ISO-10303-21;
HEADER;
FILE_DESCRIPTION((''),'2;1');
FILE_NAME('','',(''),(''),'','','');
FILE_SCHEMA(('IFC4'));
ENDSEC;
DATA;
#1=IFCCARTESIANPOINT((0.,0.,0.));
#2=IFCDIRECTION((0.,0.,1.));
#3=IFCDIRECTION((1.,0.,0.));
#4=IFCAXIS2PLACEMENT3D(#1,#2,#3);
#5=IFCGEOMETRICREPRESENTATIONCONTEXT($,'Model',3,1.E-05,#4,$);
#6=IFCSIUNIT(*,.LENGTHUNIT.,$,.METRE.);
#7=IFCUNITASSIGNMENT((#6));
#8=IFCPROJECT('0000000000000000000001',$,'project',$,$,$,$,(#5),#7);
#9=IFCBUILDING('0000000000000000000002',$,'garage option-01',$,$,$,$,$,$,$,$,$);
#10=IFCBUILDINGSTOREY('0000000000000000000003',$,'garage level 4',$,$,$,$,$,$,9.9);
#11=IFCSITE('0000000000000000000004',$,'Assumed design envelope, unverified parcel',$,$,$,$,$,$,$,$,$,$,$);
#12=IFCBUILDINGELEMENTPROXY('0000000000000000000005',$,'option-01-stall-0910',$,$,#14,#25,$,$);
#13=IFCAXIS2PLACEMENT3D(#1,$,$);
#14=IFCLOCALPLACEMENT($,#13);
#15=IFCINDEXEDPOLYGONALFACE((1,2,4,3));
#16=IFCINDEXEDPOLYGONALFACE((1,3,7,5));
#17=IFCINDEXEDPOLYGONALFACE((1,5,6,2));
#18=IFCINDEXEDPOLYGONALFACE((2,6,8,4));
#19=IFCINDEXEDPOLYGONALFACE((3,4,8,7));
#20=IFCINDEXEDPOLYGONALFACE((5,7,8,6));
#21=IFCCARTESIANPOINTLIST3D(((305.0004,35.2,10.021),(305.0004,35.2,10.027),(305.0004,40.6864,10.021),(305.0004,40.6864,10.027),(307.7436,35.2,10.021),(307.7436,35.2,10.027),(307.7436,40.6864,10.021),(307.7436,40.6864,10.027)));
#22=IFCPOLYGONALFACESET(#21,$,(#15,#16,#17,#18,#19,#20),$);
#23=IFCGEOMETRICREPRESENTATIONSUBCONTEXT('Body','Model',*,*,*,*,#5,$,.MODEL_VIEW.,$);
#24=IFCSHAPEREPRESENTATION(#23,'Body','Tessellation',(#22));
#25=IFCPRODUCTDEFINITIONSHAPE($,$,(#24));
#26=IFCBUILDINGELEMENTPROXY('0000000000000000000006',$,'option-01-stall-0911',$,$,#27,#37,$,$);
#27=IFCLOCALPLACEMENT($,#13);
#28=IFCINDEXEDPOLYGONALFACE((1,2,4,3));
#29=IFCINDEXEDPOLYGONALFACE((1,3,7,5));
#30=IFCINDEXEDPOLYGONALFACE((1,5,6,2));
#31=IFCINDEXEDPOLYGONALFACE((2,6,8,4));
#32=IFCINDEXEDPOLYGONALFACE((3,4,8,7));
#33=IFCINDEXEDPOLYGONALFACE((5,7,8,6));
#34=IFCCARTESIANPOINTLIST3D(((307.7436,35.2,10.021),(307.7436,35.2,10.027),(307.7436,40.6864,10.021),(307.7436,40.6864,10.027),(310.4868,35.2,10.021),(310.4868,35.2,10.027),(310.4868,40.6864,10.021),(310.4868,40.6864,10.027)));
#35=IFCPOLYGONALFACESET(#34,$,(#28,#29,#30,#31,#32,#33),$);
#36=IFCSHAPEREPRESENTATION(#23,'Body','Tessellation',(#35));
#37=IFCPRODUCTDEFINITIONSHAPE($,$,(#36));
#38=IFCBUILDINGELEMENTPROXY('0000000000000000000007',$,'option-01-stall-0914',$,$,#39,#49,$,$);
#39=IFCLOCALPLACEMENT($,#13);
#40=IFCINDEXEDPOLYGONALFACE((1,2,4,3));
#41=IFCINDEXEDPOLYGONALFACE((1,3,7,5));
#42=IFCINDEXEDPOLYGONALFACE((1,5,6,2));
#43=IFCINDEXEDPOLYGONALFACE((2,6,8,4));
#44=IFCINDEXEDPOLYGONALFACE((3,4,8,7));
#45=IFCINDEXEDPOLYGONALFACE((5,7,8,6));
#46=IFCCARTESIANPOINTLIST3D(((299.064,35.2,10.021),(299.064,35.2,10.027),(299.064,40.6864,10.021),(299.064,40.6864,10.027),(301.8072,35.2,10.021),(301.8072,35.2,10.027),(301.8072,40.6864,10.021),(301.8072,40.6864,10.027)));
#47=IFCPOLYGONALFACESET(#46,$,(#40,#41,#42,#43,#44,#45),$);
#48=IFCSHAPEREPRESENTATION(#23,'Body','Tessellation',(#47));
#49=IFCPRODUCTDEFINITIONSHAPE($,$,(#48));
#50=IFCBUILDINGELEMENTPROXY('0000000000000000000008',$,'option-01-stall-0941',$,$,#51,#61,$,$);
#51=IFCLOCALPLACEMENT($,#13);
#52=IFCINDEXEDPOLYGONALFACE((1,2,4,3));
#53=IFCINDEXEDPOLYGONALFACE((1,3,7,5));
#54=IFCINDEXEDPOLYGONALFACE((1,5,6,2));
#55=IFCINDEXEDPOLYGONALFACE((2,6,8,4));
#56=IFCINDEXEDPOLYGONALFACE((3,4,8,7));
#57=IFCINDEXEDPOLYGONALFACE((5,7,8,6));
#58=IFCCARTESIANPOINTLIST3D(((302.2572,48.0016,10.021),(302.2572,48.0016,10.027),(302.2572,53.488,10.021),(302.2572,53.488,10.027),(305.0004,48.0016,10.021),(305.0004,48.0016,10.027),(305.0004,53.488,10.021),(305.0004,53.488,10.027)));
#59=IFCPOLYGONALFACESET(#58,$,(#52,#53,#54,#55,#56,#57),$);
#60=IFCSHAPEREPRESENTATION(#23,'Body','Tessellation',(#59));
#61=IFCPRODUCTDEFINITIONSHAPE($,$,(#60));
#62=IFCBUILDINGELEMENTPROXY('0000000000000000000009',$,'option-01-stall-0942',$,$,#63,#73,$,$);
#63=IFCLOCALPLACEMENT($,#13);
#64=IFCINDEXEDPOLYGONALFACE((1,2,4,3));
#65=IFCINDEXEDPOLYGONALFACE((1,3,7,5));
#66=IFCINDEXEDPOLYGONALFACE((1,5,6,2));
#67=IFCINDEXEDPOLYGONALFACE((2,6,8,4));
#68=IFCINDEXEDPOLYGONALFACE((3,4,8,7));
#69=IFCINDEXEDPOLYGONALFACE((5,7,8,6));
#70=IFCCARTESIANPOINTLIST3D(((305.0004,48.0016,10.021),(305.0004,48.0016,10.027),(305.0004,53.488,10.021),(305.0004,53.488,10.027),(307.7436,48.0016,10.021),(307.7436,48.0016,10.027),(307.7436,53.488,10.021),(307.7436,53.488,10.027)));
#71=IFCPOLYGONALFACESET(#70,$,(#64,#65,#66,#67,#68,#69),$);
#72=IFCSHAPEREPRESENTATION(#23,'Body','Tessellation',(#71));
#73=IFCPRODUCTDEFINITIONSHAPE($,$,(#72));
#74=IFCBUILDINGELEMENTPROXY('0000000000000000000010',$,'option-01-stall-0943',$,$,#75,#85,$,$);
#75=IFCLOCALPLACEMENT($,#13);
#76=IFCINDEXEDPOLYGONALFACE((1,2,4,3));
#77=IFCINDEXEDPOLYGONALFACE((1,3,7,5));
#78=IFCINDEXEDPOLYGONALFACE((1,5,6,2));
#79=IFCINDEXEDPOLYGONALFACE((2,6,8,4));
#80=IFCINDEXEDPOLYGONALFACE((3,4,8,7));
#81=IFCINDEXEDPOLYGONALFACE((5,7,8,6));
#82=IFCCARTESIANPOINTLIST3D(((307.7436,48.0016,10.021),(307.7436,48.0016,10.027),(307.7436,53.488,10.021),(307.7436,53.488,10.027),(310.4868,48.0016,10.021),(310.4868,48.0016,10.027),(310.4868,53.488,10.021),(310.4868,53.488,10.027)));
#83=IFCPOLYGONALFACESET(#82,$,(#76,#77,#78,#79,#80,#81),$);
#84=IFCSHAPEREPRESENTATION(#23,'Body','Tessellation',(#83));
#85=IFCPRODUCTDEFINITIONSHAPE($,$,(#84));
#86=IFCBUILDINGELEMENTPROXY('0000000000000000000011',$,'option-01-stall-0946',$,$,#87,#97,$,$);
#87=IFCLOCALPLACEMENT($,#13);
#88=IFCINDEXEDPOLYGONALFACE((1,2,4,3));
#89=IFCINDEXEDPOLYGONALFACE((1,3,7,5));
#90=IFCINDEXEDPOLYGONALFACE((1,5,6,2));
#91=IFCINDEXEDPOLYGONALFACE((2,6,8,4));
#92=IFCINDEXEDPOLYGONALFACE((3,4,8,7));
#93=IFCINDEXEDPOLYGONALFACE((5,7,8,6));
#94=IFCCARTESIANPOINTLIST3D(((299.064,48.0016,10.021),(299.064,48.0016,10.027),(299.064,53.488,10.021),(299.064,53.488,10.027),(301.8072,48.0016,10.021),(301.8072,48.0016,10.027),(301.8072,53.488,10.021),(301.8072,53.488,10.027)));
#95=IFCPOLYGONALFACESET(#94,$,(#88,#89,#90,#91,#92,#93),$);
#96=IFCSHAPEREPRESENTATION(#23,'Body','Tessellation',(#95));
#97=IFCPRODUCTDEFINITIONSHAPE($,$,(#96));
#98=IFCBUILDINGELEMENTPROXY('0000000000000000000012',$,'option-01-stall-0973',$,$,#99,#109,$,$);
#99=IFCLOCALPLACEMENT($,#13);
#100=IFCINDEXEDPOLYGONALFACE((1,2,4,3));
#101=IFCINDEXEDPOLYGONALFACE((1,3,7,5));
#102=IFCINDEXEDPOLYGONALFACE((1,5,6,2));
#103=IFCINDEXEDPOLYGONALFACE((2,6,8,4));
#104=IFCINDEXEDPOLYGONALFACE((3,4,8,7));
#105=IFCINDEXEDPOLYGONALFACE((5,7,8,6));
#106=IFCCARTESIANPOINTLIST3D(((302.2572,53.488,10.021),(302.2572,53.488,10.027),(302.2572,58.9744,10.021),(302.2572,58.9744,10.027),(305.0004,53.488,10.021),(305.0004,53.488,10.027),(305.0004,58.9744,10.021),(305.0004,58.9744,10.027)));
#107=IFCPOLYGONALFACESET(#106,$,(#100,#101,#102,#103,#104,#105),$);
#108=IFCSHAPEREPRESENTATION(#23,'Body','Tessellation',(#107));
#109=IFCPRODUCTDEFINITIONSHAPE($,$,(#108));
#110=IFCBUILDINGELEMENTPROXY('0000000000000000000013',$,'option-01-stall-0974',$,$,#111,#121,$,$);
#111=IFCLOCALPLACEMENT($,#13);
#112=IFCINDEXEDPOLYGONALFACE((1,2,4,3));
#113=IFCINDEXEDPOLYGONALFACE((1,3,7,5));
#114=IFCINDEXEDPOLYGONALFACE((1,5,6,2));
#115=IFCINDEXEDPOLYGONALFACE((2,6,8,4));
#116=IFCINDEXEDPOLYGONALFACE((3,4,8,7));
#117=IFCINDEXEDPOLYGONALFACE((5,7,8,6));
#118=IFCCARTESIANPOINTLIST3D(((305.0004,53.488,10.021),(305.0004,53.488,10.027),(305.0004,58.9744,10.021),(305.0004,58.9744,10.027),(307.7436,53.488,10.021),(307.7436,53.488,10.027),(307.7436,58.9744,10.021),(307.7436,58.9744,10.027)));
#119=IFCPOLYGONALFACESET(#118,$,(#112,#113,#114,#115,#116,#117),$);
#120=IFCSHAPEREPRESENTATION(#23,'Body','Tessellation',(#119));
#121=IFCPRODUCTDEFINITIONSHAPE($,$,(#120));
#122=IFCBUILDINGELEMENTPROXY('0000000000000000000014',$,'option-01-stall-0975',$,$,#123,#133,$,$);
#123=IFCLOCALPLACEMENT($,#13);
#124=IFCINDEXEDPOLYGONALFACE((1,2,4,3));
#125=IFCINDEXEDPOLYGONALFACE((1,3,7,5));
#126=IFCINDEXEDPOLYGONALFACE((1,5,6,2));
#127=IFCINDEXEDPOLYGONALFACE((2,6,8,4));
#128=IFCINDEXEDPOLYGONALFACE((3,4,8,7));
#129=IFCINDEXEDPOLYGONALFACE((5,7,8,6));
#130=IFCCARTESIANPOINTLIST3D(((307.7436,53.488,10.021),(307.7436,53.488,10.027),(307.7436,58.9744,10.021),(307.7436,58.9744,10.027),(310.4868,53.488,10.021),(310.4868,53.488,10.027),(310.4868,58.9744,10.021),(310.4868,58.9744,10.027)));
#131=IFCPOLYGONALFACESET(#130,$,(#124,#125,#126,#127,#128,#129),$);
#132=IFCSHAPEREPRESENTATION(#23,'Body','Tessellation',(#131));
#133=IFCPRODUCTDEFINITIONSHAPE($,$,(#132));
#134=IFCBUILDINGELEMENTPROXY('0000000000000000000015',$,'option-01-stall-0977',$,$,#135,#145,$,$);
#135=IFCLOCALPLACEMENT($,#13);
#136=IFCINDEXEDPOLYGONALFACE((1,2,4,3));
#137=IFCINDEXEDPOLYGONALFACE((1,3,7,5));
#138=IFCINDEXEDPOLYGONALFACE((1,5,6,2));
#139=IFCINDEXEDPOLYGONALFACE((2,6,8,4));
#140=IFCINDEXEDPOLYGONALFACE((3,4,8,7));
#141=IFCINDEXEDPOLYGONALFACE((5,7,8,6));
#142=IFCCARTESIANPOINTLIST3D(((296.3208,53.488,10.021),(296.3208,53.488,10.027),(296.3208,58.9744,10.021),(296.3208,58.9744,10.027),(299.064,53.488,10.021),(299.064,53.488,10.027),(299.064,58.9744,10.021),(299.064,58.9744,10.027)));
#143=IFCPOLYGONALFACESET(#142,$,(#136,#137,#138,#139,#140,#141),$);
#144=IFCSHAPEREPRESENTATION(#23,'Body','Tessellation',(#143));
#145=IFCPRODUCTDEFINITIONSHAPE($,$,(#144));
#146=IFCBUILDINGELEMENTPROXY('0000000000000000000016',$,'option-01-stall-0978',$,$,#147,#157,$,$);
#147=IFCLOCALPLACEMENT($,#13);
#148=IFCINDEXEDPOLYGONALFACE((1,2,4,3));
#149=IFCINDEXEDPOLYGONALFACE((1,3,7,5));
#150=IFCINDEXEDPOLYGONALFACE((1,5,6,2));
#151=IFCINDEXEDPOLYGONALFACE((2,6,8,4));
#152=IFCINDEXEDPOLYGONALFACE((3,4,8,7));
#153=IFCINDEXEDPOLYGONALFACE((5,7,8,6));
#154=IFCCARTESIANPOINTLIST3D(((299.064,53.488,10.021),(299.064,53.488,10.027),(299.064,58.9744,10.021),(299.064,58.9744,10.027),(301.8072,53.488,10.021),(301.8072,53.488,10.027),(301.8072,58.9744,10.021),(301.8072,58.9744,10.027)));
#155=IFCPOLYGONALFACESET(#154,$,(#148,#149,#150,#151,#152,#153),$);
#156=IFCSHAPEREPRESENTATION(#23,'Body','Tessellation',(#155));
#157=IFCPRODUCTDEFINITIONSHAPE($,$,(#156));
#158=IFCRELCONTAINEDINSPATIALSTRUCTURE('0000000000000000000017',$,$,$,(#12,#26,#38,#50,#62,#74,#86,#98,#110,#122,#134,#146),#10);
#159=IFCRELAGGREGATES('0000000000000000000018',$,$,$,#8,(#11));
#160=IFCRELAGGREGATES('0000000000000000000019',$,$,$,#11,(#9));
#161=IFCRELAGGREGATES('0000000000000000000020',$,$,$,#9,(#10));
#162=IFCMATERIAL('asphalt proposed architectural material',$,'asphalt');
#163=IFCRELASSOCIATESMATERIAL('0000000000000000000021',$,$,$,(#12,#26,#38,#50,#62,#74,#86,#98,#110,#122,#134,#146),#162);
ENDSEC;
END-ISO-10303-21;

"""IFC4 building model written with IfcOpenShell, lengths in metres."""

from ifc_helpers import new_model, si_unit, frame, origin_with_axes, place, context, subcontext, project, spatial, rectangle, extrude, material, element, save


model = new_model("IFC4")

# Units and contexts
model_context = context("Model", 3, precision=1e-05, world=origin_with_axes())
body_context = subcontext(model_context, "Body", "Model", "MODEL_VIEW")
ifc_project = project(units=[si_unit("LENGTHUNIT", "METRE")], contexts=[model_context])

# Site, building, storey
site = spatial("IfcSite", under=ifc_project, Name="Assumed design envelope, unverified parcel")
building = spatial("IfcBuilding", under=site, Name="garage option-01")
storey = spatial("IfcBuildingStorey", under=building, Name="garage level 4", Elevation=9.9)

# Building element proxies
ifc_material_1 = material(Name="asphalt proposed architectural material", Category="asphalt")
for number, where, z_axis, x_axis, name in (
    (1, (306.372, 37.9432, 10.021), (0.0, 0.0, 1.0), (1.0, 0.0, 0.0), "option-01-stall-0910"),
    (2, (309.1152, 37.9432, 10.021), (0.0, 0.0, 1.0), (1.0, 0.0, 0.0), "option-01-stall-0911"),
    (3, (300.4356, 37.9432, 10.021), (0.0, 0.0, 1.0), (1.0, 0.0, 0.0), "option-01-stall-0914"),
    (4, (303.6288, 50.7448, 10.021), (0.0, 0.0, 1.0), (1.0, 0.0, 0.0), "option-01-stall-0941"),
    (5, (306.372, 50.7448, 10.021), (0.0, 0.0, 1.0), (1.0, 0.0, 0.0), "option-01-stall-0942"),
    (6, (309.1152, 50.7448, 10.021), (0.0, 0.0, 1.0), (1.0, 0.0, 0.0), "option-01-stall-0943"),
    (7, (300.4356, 50.7448, 10.021), (0.0, 0.0, 1.0), (1.0, 0.0, 0.0), "option-01-stall-0946"),
):
    element("IfcBuildingElementProxy", number, at=place(None, frame(where, z_axis=z_axis, x_axis=x_axis)), inside=storey, material=ifc_material_1, Name=name, context=body_context, shape_type="SweptSolid", body=[
        extrude(rectangle(XDim=2.7432, YDim=5.4864), origin_with_axes(), (0.0, 0.0, 1.0), 0.006),
    ])
for number, where, z_axis, x_axis, name in (
    (8, (303.6288, 56.2312, 10.021), (0.0, 0.0, 1.0), (1.0, 0.0, 0.0), "option-01-stall-0973"),
    (9, (306.372, 56.2312, 10.021), (0.0, 0.0, 1.0), (1.0, 0.0, 0.0), "option-01-stall-0974"),
    (10, (309.1152, 56.2312, 10.021), (0.0, 0.0, 1.0), (1.0, 0.0, 0.0), "option-01-stall-0975"),
    (11, (297.6924, 56.2312, 10.021), (0.0, 0.0, 1.0), (1.0, 0.0, 0.0), "option-01-stall-0977"),
    (12, (300.4356, 56.2312, 10.021), (0.0, 0.0, 1.0), (1.0, 0.0, 0.0), "option-01-stall-0978"),
):
    element("IfcBuildingElementProxy", number, at=place(None, frame(where, z_axis=z_axis, x_axis=x_axis)), inside=storey, material=ifc_material_1, Name=name, context=body_context, shape_type="SweptSolid", body=[
        extrude(rectangle(XDim=2.7432, YDim=5.4864), origin_with_axes(), (0.0, 0.0, 1.0), 0.006),
    ])

save(model, "model.ifc")
